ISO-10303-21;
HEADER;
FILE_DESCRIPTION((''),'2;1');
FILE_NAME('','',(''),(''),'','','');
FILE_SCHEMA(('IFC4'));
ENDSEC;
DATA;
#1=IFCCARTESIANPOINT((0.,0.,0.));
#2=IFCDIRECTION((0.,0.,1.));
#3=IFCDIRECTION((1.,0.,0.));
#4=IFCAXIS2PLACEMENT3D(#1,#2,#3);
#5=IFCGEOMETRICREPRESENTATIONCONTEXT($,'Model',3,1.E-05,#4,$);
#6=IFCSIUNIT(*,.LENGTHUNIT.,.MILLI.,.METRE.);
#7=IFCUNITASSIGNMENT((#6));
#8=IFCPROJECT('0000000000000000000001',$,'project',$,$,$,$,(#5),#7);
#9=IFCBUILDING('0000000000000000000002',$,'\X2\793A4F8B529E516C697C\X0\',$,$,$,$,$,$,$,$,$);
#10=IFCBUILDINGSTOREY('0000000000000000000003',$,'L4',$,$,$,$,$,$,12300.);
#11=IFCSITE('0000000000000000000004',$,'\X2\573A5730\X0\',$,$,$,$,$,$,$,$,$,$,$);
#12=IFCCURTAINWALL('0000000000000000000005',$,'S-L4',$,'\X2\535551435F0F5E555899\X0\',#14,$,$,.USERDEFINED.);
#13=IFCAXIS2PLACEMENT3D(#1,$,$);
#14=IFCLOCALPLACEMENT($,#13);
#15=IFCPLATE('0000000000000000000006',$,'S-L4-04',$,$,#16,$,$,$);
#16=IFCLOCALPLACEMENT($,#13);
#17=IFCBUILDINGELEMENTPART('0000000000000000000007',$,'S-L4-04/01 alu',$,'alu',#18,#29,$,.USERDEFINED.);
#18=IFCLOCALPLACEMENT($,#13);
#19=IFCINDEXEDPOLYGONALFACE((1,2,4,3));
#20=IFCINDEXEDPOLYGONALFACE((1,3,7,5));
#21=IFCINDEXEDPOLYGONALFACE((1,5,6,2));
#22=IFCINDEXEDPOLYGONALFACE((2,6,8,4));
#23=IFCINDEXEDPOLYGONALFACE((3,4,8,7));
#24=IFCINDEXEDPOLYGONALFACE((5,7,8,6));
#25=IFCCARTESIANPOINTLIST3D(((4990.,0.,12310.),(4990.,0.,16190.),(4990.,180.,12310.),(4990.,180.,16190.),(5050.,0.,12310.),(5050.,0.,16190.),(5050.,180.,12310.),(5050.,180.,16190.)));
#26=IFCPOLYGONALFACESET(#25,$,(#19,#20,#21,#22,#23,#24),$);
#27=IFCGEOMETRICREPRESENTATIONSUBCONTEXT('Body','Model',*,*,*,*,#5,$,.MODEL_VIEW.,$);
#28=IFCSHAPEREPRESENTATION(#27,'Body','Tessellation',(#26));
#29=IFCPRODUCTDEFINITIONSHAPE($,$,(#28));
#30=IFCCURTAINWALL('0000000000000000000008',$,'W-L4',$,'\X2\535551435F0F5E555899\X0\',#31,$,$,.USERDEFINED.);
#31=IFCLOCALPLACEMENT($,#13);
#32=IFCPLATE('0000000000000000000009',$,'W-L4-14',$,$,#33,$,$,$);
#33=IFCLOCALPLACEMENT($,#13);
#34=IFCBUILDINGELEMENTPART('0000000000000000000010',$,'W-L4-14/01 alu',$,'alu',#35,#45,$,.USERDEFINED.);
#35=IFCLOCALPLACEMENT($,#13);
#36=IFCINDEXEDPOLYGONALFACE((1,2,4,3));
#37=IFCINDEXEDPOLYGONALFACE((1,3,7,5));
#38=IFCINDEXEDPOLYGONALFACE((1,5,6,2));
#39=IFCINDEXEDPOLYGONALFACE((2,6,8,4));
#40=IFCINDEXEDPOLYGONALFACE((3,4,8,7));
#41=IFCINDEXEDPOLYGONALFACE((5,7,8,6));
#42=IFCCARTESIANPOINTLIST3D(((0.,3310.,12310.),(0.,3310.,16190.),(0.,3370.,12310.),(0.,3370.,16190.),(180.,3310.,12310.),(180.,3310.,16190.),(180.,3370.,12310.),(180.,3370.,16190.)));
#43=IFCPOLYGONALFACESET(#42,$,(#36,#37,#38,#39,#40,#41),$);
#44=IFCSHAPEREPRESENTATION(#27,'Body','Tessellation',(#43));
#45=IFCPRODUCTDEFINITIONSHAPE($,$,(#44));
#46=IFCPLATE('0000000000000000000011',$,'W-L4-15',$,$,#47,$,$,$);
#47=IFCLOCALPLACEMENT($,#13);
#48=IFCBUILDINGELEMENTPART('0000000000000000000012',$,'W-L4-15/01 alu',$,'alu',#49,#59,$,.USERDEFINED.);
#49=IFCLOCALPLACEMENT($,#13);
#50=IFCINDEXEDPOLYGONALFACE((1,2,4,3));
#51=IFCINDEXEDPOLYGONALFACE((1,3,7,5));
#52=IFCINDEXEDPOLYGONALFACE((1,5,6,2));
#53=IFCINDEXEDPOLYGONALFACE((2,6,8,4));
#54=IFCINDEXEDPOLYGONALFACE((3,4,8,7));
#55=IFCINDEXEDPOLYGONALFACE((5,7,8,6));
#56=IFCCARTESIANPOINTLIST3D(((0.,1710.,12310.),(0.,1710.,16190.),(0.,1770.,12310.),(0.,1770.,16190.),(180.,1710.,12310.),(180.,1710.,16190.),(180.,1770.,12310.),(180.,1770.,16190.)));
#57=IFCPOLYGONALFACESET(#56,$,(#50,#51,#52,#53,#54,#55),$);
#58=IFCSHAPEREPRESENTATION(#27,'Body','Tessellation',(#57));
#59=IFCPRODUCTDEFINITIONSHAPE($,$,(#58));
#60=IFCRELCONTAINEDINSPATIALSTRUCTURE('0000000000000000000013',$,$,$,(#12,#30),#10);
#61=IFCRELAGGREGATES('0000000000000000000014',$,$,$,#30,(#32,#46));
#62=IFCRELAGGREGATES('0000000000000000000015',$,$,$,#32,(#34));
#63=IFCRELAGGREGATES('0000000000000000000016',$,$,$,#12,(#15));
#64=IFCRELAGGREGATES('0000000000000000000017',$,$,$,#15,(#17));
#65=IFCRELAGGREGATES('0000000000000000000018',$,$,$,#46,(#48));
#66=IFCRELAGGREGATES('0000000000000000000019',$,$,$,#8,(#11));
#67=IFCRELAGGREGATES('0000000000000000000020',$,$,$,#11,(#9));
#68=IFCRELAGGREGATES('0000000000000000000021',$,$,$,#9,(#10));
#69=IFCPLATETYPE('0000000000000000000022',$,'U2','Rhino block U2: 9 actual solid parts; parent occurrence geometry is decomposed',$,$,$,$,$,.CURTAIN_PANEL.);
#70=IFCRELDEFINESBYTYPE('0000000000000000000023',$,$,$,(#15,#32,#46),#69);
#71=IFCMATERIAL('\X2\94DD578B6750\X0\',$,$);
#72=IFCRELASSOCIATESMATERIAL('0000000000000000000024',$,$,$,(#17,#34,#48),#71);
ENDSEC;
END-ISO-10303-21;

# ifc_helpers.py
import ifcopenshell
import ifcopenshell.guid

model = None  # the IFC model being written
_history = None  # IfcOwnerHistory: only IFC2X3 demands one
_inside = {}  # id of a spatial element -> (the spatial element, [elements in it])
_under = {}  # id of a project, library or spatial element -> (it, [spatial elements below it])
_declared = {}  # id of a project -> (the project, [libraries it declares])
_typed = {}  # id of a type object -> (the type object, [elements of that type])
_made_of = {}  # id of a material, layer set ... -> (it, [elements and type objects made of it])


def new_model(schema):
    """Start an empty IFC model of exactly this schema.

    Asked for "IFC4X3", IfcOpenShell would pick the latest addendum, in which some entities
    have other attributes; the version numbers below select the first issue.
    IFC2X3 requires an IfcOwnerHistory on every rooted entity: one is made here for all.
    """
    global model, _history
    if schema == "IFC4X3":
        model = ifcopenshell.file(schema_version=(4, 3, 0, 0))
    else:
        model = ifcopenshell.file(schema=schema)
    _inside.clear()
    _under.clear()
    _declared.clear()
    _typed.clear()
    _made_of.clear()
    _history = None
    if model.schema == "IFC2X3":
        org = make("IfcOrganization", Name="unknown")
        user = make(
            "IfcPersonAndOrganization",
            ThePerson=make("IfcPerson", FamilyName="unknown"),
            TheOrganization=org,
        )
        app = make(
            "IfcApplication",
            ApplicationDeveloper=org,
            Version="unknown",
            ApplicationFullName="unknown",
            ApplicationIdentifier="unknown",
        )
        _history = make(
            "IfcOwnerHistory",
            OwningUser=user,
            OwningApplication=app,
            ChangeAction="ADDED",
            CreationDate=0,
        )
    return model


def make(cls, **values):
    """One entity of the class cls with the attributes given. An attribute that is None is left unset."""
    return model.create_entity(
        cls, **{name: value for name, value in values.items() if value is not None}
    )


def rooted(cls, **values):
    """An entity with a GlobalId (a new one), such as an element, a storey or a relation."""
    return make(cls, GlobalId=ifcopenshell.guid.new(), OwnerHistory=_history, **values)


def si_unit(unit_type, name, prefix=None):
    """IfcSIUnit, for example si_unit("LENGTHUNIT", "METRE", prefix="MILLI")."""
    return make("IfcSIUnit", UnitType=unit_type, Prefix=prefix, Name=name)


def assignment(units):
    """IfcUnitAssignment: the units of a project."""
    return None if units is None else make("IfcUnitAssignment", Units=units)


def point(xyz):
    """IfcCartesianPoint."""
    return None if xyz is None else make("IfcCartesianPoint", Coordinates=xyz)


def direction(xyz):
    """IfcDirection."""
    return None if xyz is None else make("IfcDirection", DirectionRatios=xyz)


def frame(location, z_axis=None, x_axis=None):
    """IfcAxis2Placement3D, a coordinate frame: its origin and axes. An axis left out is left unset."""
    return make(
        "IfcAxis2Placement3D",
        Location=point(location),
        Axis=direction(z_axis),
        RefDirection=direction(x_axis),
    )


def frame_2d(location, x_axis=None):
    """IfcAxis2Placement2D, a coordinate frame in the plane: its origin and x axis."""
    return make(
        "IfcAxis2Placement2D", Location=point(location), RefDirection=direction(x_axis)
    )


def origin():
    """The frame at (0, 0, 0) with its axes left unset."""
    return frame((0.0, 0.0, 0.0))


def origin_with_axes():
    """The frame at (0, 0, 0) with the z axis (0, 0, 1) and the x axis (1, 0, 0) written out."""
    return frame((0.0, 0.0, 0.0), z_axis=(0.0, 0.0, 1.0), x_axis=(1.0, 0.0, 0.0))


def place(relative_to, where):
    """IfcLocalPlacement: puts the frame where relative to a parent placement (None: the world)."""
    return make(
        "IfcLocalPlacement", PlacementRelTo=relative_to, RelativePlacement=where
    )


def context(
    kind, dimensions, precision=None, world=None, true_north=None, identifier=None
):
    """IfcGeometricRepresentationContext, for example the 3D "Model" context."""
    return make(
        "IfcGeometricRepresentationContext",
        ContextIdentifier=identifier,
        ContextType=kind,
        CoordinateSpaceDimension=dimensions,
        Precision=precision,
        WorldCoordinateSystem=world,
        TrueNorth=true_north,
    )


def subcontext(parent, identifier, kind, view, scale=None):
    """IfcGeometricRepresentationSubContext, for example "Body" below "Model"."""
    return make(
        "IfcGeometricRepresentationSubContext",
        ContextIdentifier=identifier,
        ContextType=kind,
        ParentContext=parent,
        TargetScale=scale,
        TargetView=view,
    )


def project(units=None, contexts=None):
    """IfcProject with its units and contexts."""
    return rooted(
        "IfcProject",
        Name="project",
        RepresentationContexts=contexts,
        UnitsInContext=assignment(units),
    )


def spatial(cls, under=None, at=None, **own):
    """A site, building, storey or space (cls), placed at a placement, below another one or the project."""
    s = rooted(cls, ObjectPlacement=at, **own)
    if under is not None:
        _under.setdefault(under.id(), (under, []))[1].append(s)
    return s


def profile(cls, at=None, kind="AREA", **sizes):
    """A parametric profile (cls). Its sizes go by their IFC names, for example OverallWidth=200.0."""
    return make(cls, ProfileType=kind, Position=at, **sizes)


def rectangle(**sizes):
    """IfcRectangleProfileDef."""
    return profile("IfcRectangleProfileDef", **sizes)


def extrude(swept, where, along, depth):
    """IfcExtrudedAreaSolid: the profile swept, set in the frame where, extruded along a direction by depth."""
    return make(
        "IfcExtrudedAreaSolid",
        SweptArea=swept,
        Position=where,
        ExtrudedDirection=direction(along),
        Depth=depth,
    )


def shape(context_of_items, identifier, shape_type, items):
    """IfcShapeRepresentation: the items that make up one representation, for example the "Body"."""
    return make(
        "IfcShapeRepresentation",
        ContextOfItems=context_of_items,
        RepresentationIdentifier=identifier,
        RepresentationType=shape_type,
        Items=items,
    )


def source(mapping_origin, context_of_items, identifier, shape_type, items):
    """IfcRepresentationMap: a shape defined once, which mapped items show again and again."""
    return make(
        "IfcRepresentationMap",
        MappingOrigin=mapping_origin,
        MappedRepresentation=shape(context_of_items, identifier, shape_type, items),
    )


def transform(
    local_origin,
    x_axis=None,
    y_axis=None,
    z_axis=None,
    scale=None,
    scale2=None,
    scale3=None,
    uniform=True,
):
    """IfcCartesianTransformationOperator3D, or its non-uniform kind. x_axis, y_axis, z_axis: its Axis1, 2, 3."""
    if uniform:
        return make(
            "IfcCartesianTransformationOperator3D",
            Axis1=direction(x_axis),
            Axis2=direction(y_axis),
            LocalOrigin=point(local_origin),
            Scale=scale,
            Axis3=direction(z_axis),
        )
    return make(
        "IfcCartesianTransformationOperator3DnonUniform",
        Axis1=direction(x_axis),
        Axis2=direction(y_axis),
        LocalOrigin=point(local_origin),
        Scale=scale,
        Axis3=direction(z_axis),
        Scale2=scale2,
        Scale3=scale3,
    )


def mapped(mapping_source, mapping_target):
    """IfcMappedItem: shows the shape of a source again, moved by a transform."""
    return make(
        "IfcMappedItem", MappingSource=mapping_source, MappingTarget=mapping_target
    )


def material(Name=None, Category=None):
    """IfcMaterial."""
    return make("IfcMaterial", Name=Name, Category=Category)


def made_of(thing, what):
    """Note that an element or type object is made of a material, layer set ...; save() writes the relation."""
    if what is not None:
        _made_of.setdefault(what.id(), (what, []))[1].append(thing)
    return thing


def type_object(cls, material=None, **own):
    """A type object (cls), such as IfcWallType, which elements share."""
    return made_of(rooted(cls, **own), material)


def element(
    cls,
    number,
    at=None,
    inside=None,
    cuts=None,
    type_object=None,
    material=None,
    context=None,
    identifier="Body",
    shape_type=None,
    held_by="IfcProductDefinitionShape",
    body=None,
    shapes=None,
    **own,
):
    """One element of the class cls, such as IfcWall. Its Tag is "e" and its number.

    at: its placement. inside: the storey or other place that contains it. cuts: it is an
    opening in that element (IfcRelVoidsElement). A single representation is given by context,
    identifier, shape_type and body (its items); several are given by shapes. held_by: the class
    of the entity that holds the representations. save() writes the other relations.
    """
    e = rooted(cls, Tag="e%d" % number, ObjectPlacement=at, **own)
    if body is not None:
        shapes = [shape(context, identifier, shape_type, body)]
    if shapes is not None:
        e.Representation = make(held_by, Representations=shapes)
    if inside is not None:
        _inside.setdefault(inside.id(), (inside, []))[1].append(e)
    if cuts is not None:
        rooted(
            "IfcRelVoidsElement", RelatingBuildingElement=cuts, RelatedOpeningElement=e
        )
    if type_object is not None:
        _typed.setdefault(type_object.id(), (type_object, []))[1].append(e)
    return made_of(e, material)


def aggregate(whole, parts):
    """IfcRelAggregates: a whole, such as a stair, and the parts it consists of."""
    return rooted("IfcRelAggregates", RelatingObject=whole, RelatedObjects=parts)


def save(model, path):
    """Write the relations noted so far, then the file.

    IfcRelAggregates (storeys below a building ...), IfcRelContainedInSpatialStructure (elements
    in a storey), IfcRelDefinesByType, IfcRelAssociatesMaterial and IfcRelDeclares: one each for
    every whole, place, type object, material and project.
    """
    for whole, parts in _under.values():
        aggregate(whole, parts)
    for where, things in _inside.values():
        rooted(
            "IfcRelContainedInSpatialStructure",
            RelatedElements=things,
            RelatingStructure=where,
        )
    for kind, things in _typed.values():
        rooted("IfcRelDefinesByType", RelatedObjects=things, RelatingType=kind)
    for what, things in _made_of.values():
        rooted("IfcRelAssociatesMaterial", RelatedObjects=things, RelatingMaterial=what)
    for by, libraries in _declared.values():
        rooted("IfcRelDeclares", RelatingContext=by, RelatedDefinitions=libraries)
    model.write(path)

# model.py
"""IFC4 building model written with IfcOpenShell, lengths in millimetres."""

from ifc_helpers import new_model, si_unit, frame, frame_2d, origin, origin_with_axes, place, context, subcontext, project, spatial, rectangle, extrude, source, transform, mapped, material, type_object, element, aggregate, save


model = new_model("IFC4")

# Units and contexts
model_context = context("Model", 3, precision=1e-05, world=origin_with_axes())
body_context = subcontext(model_context, "Body", "Model", "MODEL_VIEW")
ifc_project = project(units=[si_unit("LENGTHUNIT", "METRE", prefix="MILLI")], contexts=[model_context])

# Site, building, storey
site = spatial("IfcSite", under=ifc_project, Name="场地")
building = spatial("IfcBuilding", under=site, Name="示例办公楼")
storey = spatial("IfcBuildingStorey", under=building, Name="L4", Elevation=12300.0)

# Curtain wall, plate, building element part
curtain_wall_1 = element("IfcCurtainWall", 1, inside=storey, Name="S-L4", ObjectType="单元式幕墙", PredefinedType="USERDEFINED")
plate_type = type_object("IfcPlateType", Name="U2", Description="Rhino block U2: 9 actual solid parts; parent occurrence geometry is decomposed", PredefinedType="CURTAIN_PANEL")
plate_1_placement = place(None, frame((4990.0, 0.0, 12310.0), z_axis=(0.0, 0.0, 1.0), x_axis=(1.0, 0.0, 0.0)))
plate_1 = element("IfcPlate", 2, at=plate_1_placement, type_object=plate_type, Name="S-L4-04")
ifc_material_1 = material(Name="铝型材")
shared_shape_1 = source(origin(), body_context, "Body", "SweptSolid", [
    extrude(rectangle(XDim=60.0, YDim=180.0, at=frame_2d((30.0, 90.0))), origin(), (0.0, 0.0, 1.0), 3880.0),
])
building_element_part_1_placement = place(plate_1_placement, origin())
building_element_part_1 = element("IfcBuildingElementPart", 3, at=building_element_part_1_placement, material=ifc_material_1, Name="S-L4-04/01 alu", ObjectType="alu", PredefinedType="USERDEFINED", context=body_context, shape_type="MappedRepresentation", body=[
    mapped(shared_shape_1, transform((0.0, 0.0, 0.0))),
])

# Curtain wall, plates, building element parts
curtain_wall_2 = element("IfcCurtainWall", 4, inside=storey, Name="W-L4", ObjectType="单元式幕墙", PredefinedType="USERDEFINED")
plate_2_placement = place(None, frame((0.0, 3370.0, 12310.0), z_axis=(0.0, 0.0, 1.0), x_axis=(0.0, -1.0, 0.0)))
plate_2 = element("IfcPlate", 5, at=plate_2_placement, type_object=plate_type, Name="W-L4-14")
building_element_part_2_placement = place(plate_2_placement, origin())
building_element_part_2 = element("IfcBuildingElementPart", 6, at=building_element_part_2_placement, material=ifc_material_1, Name="W-L4-14/01 alu", ObjectType="alu", PredefinedType="USERDEFINED", context=body_context, shape_type="MappedRepresentation", body=[
    mapped(shared_shape_1, transform((0.0, 0.0, 0.0))),
])
plate_3_placement = place(None, frame((0.0, 1770.0, 12310.0), z_axis=(0.0, 0.0, 1.0), x_axis=(0.0, -1.0, 0.0)))
plate_3 = element("IfcPlate", 7, at=plate_3_placement, type_object=plate_type, Name="W-L4-15")
aggregate(curtain_wall_2, [plate_2, plate_3])
building_element_part_3_placement = place(plate_3_placement, origin())
building_element_part_3 = element("IfcBuildingElementPart", 8, at=building_element_part_3_placement, material=ifc_material_1, Name="W-L4-15/01 alu", ObjectType="alu", PredefinedType="USERDEFINED", context=body_context, shape_type="MappedRepresentation", body=[
    mapped(shared_shape_1, transform((0.0, 0.0, 0.0))),
])

aggregate(plate_2, [building_element_part_2])

aggregate(curtain_wall_1, [plate_1])

aggregate(plate_1, [building_element_part_1])
aggregate(plate_3, [building_element_part_3])

save(model, "model.ifc")
